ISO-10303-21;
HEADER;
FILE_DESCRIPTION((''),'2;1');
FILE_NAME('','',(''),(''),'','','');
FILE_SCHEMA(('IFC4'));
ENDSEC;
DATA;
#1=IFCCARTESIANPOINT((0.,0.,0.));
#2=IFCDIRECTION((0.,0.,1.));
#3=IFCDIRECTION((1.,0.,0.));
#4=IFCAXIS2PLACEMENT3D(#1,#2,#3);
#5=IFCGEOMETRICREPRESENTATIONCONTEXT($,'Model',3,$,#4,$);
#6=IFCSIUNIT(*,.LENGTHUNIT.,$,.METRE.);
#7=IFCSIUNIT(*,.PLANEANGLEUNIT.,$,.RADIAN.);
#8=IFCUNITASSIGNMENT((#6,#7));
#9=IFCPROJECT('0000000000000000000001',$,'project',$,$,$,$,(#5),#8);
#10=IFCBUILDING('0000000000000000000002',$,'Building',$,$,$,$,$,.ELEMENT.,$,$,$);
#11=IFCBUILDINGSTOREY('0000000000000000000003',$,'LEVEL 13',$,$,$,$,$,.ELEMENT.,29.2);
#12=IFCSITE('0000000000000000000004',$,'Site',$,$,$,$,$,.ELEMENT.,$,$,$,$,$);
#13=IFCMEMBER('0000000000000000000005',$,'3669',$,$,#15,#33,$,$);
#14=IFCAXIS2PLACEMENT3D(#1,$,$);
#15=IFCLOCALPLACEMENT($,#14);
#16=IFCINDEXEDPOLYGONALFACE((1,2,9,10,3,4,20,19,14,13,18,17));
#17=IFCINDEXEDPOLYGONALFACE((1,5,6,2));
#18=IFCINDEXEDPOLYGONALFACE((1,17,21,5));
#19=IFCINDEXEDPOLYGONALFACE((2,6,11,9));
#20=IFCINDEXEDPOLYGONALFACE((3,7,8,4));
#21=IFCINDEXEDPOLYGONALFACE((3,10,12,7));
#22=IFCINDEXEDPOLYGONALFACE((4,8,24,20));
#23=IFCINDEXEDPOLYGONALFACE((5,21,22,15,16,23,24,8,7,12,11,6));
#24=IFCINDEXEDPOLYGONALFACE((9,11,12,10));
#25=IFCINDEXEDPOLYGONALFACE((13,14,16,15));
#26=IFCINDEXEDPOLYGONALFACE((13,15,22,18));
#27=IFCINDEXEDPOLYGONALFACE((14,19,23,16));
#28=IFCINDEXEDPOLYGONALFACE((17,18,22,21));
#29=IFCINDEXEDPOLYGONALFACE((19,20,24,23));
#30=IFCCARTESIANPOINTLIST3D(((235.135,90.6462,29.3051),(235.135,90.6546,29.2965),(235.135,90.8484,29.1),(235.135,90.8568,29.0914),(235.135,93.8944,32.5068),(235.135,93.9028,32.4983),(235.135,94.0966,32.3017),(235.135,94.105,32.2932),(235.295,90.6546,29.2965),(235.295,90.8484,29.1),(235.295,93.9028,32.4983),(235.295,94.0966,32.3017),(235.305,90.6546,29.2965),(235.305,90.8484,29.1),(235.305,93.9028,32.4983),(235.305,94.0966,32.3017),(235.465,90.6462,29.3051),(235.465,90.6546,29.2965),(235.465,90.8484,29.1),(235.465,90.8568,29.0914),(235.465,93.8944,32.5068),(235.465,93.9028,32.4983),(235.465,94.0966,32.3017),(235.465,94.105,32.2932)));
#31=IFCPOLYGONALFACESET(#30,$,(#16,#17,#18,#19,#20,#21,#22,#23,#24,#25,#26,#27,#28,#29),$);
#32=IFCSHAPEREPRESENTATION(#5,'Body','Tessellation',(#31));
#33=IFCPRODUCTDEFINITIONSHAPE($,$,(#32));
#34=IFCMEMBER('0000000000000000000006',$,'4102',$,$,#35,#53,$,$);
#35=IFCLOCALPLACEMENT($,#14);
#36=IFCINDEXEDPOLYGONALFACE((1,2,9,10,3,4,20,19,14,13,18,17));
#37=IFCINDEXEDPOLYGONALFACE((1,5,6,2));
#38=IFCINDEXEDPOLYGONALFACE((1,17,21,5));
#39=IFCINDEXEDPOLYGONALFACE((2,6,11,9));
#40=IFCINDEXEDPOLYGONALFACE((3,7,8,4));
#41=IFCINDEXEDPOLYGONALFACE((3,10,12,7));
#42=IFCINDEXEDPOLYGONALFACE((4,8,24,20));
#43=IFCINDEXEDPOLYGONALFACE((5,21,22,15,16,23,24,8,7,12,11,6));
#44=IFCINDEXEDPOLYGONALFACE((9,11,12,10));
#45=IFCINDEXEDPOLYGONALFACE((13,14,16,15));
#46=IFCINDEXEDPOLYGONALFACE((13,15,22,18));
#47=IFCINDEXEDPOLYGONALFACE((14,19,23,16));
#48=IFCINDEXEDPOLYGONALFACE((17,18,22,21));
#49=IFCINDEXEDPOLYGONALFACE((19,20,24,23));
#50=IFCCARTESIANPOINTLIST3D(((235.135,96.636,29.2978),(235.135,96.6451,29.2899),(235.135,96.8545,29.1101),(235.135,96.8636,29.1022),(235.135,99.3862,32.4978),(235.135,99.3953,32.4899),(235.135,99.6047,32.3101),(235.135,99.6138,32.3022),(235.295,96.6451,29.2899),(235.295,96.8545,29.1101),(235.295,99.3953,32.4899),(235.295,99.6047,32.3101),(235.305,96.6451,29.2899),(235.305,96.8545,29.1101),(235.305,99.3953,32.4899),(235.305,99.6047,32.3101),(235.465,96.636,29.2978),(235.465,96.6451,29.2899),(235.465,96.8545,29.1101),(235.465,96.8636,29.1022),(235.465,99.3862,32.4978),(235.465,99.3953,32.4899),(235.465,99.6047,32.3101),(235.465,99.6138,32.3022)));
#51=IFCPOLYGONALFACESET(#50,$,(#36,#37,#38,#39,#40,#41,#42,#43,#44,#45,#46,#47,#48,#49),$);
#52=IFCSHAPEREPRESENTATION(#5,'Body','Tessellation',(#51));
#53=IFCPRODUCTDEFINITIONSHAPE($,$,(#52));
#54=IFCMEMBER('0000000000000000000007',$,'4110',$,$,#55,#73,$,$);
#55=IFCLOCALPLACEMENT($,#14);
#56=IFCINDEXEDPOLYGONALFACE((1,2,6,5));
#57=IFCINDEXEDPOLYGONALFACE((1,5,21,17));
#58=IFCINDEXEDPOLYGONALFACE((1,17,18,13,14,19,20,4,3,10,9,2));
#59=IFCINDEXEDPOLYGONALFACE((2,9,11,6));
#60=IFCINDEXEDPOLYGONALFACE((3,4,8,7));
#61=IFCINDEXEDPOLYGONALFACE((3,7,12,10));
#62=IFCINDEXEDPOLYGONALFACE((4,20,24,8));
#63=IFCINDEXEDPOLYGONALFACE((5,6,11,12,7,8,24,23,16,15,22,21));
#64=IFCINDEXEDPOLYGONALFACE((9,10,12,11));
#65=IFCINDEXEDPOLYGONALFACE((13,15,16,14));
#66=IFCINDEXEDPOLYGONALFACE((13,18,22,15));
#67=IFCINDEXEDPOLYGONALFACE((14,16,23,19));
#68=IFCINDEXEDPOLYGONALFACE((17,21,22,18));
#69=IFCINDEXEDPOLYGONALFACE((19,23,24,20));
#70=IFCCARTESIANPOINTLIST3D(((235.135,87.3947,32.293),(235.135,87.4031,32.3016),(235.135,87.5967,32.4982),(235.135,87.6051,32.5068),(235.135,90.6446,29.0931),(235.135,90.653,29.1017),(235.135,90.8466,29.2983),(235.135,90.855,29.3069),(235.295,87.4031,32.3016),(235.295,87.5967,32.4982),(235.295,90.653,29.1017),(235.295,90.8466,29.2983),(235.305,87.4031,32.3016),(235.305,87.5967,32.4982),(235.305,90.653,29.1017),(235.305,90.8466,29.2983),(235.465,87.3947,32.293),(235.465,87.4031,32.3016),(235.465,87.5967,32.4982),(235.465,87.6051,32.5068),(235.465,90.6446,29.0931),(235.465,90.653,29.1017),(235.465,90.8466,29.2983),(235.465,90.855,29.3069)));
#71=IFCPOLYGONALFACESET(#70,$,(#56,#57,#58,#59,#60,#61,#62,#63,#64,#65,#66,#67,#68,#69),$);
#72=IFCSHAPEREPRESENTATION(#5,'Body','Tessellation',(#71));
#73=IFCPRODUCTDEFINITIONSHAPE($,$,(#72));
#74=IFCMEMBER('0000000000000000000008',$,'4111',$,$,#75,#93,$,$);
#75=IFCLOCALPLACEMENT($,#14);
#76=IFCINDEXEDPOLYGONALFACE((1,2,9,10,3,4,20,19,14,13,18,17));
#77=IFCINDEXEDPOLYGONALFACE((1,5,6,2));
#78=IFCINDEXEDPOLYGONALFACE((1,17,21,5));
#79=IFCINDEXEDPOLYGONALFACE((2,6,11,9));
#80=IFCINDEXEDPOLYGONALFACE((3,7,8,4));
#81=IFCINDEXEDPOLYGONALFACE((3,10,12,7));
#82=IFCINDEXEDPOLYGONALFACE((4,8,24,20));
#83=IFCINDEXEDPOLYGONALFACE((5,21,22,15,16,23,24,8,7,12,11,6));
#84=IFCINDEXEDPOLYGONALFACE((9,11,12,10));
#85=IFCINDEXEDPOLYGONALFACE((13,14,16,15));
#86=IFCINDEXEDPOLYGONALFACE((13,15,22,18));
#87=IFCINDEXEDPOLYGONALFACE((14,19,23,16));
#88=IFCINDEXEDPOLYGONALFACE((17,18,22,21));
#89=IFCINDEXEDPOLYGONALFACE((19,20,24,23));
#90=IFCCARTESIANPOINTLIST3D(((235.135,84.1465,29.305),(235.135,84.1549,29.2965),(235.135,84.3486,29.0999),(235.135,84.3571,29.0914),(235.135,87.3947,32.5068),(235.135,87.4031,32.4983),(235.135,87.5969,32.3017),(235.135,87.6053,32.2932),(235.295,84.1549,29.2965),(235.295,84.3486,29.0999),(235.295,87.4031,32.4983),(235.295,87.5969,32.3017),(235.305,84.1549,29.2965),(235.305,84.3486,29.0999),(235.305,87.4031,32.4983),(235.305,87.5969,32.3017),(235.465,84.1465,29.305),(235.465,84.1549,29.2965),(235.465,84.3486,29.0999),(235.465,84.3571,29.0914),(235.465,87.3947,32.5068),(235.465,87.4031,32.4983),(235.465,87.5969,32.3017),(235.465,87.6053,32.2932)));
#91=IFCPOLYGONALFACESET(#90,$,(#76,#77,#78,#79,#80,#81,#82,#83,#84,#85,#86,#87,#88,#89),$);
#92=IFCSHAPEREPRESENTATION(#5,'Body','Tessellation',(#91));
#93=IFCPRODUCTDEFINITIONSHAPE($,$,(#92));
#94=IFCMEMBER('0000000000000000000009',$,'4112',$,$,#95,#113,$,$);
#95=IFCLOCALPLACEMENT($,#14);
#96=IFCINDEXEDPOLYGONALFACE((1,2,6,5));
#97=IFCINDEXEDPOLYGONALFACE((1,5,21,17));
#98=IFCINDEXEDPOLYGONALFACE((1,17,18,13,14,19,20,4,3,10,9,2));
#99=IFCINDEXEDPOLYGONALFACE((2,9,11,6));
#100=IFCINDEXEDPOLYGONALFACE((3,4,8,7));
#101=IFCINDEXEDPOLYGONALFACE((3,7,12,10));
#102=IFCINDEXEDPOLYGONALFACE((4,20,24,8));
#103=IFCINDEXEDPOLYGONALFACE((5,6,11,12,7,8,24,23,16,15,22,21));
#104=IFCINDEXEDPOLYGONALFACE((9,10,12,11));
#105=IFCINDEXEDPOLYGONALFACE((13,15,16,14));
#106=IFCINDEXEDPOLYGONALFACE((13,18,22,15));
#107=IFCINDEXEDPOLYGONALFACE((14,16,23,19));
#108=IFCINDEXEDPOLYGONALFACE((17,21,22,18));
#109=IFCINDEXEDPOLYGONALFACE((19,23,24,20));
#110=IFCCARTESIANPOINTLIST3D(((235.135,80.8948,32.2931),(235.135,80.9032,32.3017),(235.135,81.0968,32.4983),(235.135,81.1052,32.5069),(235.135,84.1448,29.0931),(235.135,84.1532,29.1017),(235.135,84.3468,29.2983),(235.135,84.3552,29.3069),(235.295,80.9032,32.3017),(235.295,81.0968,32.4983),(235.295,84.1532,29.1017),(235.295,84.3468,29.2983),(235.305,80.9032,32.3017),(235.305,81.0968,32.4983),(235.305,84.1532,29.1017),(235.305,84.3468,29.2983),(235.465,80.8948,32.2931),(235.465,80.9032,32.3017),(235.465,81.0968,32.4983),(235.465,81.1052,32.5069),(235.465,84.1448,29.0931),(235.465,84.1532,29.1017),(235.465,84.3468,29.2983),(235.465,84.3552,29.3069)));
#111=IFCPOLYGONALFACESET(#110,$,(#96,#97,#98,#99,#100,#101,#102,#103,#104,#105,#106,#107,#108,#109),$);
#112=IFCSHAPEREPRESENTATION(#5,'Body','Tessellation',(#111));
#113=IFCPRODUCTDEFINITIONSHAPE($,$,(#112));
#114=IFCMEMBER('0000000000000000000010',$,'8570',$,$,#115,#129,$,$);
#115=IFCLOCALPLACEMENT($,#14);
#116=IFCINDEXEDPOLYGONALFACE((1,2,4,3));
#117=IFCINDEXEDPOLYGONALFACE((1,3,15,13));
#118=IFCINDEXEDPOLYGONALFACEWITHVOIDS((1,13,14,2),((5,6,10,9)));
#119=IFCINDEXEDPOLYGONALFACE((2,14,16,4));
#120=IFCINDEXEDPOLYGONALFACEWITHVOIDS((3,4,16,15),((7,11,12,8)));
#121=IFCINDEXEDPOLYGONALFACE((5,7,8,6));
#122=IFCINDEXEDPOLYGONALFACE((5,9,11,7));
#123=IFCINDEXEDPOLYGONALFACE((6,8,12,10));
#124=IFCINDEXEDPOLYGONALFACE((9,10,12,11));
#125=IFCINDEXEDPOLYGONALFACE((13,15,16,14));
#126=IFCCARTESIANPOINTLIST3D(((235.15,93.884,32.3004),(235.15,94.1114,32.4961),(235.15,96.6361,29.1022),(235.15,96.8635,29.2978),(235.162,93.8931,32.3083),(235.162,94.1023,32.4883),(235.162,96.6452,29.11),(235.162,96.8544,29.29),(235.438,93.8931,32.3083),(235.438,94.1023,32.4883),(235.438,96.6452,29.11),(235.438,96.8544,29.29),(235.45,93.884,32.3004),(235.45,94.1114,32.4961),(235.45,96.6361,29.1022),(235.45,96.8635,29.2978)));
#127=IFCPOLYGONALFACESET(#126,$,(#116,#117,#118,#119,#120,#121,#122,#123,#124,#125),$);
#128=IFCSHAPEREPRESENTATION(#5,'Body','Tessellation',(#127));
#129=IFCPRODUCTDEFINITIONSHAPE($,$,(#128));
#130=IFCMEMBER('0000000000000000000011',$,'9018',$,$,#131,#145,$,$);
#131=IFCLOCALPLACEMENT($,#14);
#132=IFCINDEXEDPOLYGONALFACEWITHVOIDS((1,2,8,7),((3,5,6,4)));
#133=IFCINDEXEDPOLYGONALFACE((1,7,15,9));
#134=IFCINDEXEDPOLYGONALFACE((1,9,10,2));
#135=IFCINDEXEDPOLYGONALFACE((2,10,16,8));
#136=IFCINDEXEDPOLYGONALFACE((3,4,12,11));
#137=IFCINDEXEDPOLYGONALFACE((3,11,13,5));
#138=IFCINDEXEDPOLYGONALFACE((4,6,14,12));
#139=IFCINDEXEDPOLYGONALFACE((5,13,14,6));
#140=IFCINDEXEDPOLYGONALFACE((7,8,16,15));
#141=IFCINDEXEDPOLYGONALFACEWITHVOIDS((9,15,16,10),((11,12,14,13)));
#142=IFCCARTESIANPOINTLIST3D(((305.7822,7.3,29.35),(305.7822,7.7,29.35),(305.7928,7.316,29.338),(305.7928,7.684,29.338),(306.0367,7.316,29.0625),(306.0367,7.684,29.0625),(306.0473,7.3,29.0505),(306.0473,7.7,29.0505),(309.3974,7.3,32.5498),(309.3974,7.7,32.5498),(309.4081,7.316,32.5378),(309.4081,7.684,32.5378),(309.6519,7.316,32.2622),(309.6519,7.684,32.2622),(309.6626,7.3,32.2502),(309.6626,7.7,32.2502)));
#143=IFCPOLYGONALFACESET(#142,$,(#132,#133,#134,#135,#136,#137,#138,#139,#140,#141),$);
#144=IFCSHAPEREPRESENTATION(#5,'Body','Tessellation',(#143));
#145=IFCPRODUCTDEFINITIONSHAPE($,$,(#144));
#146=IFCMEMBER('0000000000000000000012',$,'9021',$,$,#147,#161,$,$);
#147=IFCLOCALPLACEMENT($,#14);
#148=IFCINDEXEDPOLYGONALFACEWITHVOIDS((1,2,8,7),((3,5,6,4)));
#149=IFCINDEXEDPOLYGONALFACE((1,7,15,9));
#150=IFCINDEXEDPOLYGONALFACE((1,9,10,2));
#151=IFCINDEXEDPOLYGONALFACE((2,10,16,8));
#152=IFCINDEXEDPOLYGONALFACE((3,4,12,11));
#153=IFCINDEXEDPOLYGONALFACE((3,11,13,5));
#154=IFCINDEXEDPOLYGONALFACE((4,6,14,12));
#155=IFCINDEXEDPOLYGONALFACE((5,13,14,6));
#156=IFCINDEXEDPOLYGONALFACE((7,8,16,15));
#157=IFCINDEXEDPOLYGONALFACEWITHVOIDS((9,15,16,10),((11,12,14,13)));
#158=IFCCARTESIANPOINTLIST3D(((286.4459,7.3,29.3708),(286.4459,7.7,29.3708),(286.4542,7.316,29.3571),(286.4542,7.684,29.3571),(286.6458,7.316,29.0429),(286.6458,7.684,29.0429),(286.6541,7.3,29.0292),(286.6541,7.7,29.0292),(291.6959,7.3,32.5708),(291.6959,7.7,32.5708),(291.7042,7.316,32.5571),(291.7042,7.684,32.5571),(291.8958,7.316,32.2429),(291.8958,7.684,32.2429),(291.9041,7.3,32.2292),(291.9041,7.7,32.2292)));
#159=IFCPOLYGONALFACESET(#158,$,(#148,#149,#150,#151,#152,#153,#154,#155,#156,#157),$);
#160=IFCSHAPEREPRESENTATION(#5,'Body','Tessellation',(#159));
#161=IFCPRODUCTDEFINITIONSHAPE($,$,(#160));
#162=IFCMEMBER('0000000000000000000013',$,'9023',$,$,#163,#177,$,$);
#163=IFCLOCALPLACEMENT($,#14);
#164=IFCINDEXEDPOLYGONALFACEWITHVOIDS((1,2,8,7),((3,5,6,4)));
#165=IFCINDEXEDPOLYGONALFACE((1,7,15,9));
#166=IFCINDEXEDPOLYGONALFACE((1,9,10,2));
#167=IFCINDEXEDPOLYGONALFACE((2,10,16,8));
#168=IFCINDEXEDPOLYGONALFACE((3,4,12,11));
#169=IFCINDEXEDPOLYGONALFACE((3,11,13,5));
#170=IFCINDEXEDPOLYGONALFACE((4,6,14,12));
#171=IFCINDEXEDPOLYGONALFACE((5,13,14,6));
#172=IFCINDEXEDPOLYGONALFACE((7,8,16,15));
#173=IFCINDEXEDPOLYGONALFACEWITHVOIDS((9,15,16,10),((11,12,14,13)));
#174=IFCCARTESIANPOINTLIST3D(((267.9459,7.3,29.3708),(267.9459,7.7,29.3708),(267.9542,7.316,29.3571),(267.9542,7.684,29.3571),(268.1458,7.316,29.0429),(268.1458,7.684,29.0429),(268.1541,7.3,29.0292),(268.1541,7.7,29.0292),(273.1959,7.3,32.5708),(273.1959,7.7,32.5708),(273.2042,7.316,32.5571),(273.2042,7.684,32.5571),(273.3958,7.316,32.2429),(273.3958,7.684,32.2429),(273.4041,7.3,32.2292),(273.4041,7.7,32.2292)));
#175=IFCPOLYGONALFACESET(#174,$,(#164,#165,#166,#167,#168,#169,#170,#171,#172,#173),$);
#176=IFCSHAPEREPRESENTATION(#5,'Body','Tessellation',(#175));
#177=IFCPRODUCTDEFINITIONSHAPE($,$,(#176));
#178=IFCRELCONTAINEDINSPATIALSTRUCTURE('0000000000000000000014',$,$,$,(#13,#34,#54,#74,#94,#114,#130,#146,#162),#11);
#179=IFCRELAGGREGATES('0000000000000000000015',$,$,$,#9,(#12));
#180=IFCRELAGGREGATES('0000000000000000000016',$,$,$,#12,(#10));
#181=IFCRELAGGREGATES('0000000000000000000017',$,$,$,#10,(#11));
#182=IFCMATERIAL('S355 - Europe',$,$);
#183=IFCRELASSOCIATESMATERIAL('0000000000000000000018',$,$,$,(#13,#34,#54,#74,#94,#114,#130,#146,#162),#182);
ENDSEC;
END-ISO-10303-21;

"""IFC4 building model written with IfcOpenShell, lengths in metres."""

from ifc_helpers import new_model, si_unit, frame, origin_with_axes, origin_2d_with_axis, place, context, project, spatial, hollow_rectangle, i_section, extrude, material, material_profile, profile_set, profile_usage, element, save


model = new_model("IFC4")

# Units and contexts
model_context = context("Model", 3, world=origin_with_axes())
ifc_project = project(units=[si_unit("LENGTHUNIT", "METRE"), si_unit("PLANEANGLEUNIT", "RADIAN")], contexts=[model_context])

# Site, building, storey
site = spatial("IfcSite", under=ifc_project, Name="Site", CompositionType="ELEMENT")
building = spatial("IfcBuilding", under=site, Name="Building", CompositionType="ELEMENT")
storey = spatial("IfcBuildingStorey", under=building, Name="LEVEL 13", CompositionType="ELEMENT", Elevation=29.2)

# Members
ifc_material = material(Name="S355 - Europe")
ifc_material_profile_1 = material_profile(ifc_material, i_section(OverallWidth=0.33, OverallDepth=0.3, WebThickness=0.01, FlangeThickness=0.012, at=origin_2d_with_axis()))
ifc_profile_set_1 = profile_set([ifc_material_profile_1])
ifc_profile_usage_1 = profile_usage(ifc_profile_set_1, cardinal=10)
member_1_placement = place(None, frame((235.3, 93.9997, 32.4), z_axis=(0.0, -0.712178, -0.701999), x_axis=(1.0, 0.0, 0.0)))
element("IfcMember", 1, at=member_1_placement, inside=storey, material=ifc_profile_usage_1, Name="3669", context=model_context, shape_type="SweptSolid", body=[
    extrude(i_section(OverallWidth=0.33, OverallDepth=0.3, WebThickness=0.01, FlangeThickness=0.012, at=origin_2d_with_axis()), origin_with_axes(), (0.0, 0.0, 1.0), 4.5609),
])
ifc_material_profile_2 = material_profile(ifc_material, i_section(OverallWidth=0.33, OverallDepth=0.3, WebThickness=0.01, FlangeThickness=0.012, at=origin_2d_with_axis()))
ifc_profile_set_2 = profile_set([ifc_material_profile_2])
ifc_profile_usage_2 = profile_usage(ifc_profile_set_2, cardinal=10)
member_2_placement = place(None, frame((235.3, 99.5, 32.4), z_axis=(0.0, -0.651794, -0.758396), x_axis=(1.0, 0.0, 0.0)))
element("IfcMember", 2, at=member_2_placement, inside=storey, material=ifc_profile_usage_2, Name="4102", context=model_context, shape_type="SweptSolid", body=[
    extrude(i_section(OverallWidth=0.33, OverallDepth=0.3, WebThickness=0.01, FlangeThickness=0.012, at=origin_2d_with_axis()), origin_with_axes(), (0.0, 0.0, 1.0), 4.2194),
])
ifc_material_profile_3 = material_profile(ifc_material, i_section(OverallWidth=0.33, OverallDepth=0.3, WebThickness=0.01, FlangeThickness=0.012, at=origin_2d_with_axis()))
ifc_profile_set_3 = profile_set([ifc_material_profile_3])
ifc_profile_usage_3 = profile_usage(ifc_profile_set_3, cardinal=10)
member_3_placement = place(None, frame((235.3, 90.7498, 29.2), z_axis=(0.0, -0.712567, 0.701604), x_axis=(1.0, 0.0, 0.0)))
element("IfcMember", 3, at=member_3_placement, inside=storey, material=ifc_profile_usage_3, Name="4110", context=model_context, shape_type="SweptSolid", body=[
    extrude(i_section(OverallWidth=0.33, OverallDepth=0.3, WebThickness=0.01, FlangeThickness=0.012, at=origin_2d_with_axis()), origin_with_axes(), (0.0, 0.0, 1.0), 4.5608),
])
ifc_material_profile_4 = material_profile(ifc_material, i_section(OverallWidth=0.33, OverallDepth=0.3, WebThickness=0.01, FlangeThickness=0.012, at=origin_2d_with_axis()))
ifc_profile_set_4 = profile_set([ifc_material_profile_4])
ifc_profile_usage_4 = profile_usage(ifc_profile_set_4, cardinal=10)
member_4_placement = place(None, frame((235.3, 87.5, 32.4), z_axis=(0.0, -0.712178, -0.701999), x_axis=(1.0, 0.0, 0.0)))
element("IfcMember", 4, at=member_4_placement, inside=storey, material=ifc_profile_usage_4, Name="4111", context=model_context, shape_type="SweptSolid", body=[
    extrude(i_section(OverallWidth=0.33, OverallDepth=0.3, WebThickness=0.01, FlangeThickness=0.012, at=origin_2d_with_axis()), origin_with_axes(), (0.0, 0.0, 1.0), 4.561),
])
ifc_material_profile_5 = material_profile(ifc_material, i_section(OverallWidth=0.33, OverallDepth=0.3, WebThickness=0.01, FlangeThickness=0.012, at=origin_2d_with_axis()))
ifc_profile_set_5 = profile_set([ifc_material_profile_5])
ifc_profile_usage_5 = profile_usage(ifc_profile_set_5, cardinal=10)
member_5_placement = place(None, frame((235.3, 84.25, 29.2), z_axis=(0.0, -0.712567, 0.701604), x_axis=(1.0, 0.0, 0.0)))
element("IfcMember", 5, at=member_5_placement, inside=storey, material=ifc_profile_usage_5, Name="4112", context=model_context, shape_type="SweptSolid", body=[
    extrude(i_section(OverallWidth=0.33, OverallDepth=0.3, WebThickness=0.01, FlangeThickness=0.012, at=origin_2d_with_axis()), origin_with_axes(), (0.0, 0.0, 1.0), 4.561),
])
ifc_material_profile_6 = material_profile(ifc_material, hollow_rectangle(XDim=0.3, YDim=0.3, WallThickness=0.012, at=origin_2d_with_axis()))
ifc_profile_set_6 = profile_set([ifc_material_profile_6])
ifc_profile_usage_6 = profile_usage(ifc_profile_set_6, cardinal=10)
member_6_placement = place(None, frame((235.3, 96.7498, 29.2), z_axis=(0.0, -0.652257, 0.757998), x_axis=(1.0, 0.0, 0.0)))
element("IfcMember", 6, at=member_6_placement, inside=storey, material=ifc_profile_usage_6, Name="8570", context=model_context, shape_type="SweptSolid", body=[
    extrude(hollow_rectangle(XDim=0.3, YDim=0.3, WallThickness=0.012, at=origin_2d_with_axis()), origin_with_axes(), (0.0, 0.0, 1.0), 4.2194),
])
ifc_material_profile_7 = material_profile(ifc_material, hollow_rectangle(XDim=0.4, YDim=0.4, WallThickness=0.016, at=origin_2d_with_axis()))
ifc_profile_set_7 = profile_set([ifc_material_profile_7])
ifc_profile_usage_7 = profile_usage(ifc_profile_set_7, cardinal=10)
member_7_placement = place(None, frame((309.53, 7.5, 32.4), z_axis=(-0.748825, 0.0, -0.662768), x_axis=(0.0, -1.0, 0.0)))
element("IfcMember", 7, at=member_7_placement, inside=storey, material=ifc_profile_usage_7, Name="9018", context=model_context, shape_type="SweptSolid", body=[
    extrude(hollow_rectangle(XDim=0.4, YDim=0.4, WallThickness=0.016, at=origin_2d_with_axis()), origin_with_axes(), (0.0, 0.0, 1.0), 4.8279),
])
ifc_material_profile_8 = material_profile(ifc_material, hollow_rectangle(XDim=0.4, YDim=0.4, WallThickness=0.016, at=origin_2d_with_axis()))
ifc_profile_set_8 = profile_set([ifc_material_profile_8])
ifc_profile_usage_8 = profile_usage(ifc_profile_set_8, cardinal=10)
member_8_placement = place(None, frame((291.8, 7.5, 32.4), z_axis=(-0.853884, 0.0, -0.520463), x_axis=(0.0, -1.0, 0.0)))
element("IfcMember", 8, at=member_8_placement, inside=storey, material=ifc_profile_usage_8, Name="9021", context=model_context, shape_type="SweptSolid", body=[
    extrude(hollow_rectangle(XDim=0.4, YDim=0.4, WallThickness=0.016, at=origin_2d_with_axis()), origin_with_axes(), (0.0, 0.0, 1.0), 6.1484),
])
ifc_material_profile_9 = material_profile(ifc_material, hollow_rectangle(XDim=0.4, YDim=0.4, WallThickness=0.016, at=origin_2d_with_axis()))
ifc_profile_set_9 = profile_set([ifc_material_profile_9])
ifc_profile_usage_9 = profile_usage(ifc_profile_set_9, cardinal=10)
member_9_placement = place(None, frame((273.3, 7.5, 32.4), z_axis=(-0.853884, 0.0, -0.520463), x_axis=(0.0, -1.0, 0.0)))
element("IfcMember", 9, at=member_9_placement, inside=storey, material=ifc_profile_usage_9, Name="9023", context=model_context, shape_type="SweptSolid", body=[
    extrude(hollow_rectangle(XDim=0.4, YDim=0.4, WallThickness=0.016, at=origin_2d_with_axis()), origin_with_axes(), (0.0, 0.0, 1.0), 6.1484),
])

save(model, "model.ifc")
